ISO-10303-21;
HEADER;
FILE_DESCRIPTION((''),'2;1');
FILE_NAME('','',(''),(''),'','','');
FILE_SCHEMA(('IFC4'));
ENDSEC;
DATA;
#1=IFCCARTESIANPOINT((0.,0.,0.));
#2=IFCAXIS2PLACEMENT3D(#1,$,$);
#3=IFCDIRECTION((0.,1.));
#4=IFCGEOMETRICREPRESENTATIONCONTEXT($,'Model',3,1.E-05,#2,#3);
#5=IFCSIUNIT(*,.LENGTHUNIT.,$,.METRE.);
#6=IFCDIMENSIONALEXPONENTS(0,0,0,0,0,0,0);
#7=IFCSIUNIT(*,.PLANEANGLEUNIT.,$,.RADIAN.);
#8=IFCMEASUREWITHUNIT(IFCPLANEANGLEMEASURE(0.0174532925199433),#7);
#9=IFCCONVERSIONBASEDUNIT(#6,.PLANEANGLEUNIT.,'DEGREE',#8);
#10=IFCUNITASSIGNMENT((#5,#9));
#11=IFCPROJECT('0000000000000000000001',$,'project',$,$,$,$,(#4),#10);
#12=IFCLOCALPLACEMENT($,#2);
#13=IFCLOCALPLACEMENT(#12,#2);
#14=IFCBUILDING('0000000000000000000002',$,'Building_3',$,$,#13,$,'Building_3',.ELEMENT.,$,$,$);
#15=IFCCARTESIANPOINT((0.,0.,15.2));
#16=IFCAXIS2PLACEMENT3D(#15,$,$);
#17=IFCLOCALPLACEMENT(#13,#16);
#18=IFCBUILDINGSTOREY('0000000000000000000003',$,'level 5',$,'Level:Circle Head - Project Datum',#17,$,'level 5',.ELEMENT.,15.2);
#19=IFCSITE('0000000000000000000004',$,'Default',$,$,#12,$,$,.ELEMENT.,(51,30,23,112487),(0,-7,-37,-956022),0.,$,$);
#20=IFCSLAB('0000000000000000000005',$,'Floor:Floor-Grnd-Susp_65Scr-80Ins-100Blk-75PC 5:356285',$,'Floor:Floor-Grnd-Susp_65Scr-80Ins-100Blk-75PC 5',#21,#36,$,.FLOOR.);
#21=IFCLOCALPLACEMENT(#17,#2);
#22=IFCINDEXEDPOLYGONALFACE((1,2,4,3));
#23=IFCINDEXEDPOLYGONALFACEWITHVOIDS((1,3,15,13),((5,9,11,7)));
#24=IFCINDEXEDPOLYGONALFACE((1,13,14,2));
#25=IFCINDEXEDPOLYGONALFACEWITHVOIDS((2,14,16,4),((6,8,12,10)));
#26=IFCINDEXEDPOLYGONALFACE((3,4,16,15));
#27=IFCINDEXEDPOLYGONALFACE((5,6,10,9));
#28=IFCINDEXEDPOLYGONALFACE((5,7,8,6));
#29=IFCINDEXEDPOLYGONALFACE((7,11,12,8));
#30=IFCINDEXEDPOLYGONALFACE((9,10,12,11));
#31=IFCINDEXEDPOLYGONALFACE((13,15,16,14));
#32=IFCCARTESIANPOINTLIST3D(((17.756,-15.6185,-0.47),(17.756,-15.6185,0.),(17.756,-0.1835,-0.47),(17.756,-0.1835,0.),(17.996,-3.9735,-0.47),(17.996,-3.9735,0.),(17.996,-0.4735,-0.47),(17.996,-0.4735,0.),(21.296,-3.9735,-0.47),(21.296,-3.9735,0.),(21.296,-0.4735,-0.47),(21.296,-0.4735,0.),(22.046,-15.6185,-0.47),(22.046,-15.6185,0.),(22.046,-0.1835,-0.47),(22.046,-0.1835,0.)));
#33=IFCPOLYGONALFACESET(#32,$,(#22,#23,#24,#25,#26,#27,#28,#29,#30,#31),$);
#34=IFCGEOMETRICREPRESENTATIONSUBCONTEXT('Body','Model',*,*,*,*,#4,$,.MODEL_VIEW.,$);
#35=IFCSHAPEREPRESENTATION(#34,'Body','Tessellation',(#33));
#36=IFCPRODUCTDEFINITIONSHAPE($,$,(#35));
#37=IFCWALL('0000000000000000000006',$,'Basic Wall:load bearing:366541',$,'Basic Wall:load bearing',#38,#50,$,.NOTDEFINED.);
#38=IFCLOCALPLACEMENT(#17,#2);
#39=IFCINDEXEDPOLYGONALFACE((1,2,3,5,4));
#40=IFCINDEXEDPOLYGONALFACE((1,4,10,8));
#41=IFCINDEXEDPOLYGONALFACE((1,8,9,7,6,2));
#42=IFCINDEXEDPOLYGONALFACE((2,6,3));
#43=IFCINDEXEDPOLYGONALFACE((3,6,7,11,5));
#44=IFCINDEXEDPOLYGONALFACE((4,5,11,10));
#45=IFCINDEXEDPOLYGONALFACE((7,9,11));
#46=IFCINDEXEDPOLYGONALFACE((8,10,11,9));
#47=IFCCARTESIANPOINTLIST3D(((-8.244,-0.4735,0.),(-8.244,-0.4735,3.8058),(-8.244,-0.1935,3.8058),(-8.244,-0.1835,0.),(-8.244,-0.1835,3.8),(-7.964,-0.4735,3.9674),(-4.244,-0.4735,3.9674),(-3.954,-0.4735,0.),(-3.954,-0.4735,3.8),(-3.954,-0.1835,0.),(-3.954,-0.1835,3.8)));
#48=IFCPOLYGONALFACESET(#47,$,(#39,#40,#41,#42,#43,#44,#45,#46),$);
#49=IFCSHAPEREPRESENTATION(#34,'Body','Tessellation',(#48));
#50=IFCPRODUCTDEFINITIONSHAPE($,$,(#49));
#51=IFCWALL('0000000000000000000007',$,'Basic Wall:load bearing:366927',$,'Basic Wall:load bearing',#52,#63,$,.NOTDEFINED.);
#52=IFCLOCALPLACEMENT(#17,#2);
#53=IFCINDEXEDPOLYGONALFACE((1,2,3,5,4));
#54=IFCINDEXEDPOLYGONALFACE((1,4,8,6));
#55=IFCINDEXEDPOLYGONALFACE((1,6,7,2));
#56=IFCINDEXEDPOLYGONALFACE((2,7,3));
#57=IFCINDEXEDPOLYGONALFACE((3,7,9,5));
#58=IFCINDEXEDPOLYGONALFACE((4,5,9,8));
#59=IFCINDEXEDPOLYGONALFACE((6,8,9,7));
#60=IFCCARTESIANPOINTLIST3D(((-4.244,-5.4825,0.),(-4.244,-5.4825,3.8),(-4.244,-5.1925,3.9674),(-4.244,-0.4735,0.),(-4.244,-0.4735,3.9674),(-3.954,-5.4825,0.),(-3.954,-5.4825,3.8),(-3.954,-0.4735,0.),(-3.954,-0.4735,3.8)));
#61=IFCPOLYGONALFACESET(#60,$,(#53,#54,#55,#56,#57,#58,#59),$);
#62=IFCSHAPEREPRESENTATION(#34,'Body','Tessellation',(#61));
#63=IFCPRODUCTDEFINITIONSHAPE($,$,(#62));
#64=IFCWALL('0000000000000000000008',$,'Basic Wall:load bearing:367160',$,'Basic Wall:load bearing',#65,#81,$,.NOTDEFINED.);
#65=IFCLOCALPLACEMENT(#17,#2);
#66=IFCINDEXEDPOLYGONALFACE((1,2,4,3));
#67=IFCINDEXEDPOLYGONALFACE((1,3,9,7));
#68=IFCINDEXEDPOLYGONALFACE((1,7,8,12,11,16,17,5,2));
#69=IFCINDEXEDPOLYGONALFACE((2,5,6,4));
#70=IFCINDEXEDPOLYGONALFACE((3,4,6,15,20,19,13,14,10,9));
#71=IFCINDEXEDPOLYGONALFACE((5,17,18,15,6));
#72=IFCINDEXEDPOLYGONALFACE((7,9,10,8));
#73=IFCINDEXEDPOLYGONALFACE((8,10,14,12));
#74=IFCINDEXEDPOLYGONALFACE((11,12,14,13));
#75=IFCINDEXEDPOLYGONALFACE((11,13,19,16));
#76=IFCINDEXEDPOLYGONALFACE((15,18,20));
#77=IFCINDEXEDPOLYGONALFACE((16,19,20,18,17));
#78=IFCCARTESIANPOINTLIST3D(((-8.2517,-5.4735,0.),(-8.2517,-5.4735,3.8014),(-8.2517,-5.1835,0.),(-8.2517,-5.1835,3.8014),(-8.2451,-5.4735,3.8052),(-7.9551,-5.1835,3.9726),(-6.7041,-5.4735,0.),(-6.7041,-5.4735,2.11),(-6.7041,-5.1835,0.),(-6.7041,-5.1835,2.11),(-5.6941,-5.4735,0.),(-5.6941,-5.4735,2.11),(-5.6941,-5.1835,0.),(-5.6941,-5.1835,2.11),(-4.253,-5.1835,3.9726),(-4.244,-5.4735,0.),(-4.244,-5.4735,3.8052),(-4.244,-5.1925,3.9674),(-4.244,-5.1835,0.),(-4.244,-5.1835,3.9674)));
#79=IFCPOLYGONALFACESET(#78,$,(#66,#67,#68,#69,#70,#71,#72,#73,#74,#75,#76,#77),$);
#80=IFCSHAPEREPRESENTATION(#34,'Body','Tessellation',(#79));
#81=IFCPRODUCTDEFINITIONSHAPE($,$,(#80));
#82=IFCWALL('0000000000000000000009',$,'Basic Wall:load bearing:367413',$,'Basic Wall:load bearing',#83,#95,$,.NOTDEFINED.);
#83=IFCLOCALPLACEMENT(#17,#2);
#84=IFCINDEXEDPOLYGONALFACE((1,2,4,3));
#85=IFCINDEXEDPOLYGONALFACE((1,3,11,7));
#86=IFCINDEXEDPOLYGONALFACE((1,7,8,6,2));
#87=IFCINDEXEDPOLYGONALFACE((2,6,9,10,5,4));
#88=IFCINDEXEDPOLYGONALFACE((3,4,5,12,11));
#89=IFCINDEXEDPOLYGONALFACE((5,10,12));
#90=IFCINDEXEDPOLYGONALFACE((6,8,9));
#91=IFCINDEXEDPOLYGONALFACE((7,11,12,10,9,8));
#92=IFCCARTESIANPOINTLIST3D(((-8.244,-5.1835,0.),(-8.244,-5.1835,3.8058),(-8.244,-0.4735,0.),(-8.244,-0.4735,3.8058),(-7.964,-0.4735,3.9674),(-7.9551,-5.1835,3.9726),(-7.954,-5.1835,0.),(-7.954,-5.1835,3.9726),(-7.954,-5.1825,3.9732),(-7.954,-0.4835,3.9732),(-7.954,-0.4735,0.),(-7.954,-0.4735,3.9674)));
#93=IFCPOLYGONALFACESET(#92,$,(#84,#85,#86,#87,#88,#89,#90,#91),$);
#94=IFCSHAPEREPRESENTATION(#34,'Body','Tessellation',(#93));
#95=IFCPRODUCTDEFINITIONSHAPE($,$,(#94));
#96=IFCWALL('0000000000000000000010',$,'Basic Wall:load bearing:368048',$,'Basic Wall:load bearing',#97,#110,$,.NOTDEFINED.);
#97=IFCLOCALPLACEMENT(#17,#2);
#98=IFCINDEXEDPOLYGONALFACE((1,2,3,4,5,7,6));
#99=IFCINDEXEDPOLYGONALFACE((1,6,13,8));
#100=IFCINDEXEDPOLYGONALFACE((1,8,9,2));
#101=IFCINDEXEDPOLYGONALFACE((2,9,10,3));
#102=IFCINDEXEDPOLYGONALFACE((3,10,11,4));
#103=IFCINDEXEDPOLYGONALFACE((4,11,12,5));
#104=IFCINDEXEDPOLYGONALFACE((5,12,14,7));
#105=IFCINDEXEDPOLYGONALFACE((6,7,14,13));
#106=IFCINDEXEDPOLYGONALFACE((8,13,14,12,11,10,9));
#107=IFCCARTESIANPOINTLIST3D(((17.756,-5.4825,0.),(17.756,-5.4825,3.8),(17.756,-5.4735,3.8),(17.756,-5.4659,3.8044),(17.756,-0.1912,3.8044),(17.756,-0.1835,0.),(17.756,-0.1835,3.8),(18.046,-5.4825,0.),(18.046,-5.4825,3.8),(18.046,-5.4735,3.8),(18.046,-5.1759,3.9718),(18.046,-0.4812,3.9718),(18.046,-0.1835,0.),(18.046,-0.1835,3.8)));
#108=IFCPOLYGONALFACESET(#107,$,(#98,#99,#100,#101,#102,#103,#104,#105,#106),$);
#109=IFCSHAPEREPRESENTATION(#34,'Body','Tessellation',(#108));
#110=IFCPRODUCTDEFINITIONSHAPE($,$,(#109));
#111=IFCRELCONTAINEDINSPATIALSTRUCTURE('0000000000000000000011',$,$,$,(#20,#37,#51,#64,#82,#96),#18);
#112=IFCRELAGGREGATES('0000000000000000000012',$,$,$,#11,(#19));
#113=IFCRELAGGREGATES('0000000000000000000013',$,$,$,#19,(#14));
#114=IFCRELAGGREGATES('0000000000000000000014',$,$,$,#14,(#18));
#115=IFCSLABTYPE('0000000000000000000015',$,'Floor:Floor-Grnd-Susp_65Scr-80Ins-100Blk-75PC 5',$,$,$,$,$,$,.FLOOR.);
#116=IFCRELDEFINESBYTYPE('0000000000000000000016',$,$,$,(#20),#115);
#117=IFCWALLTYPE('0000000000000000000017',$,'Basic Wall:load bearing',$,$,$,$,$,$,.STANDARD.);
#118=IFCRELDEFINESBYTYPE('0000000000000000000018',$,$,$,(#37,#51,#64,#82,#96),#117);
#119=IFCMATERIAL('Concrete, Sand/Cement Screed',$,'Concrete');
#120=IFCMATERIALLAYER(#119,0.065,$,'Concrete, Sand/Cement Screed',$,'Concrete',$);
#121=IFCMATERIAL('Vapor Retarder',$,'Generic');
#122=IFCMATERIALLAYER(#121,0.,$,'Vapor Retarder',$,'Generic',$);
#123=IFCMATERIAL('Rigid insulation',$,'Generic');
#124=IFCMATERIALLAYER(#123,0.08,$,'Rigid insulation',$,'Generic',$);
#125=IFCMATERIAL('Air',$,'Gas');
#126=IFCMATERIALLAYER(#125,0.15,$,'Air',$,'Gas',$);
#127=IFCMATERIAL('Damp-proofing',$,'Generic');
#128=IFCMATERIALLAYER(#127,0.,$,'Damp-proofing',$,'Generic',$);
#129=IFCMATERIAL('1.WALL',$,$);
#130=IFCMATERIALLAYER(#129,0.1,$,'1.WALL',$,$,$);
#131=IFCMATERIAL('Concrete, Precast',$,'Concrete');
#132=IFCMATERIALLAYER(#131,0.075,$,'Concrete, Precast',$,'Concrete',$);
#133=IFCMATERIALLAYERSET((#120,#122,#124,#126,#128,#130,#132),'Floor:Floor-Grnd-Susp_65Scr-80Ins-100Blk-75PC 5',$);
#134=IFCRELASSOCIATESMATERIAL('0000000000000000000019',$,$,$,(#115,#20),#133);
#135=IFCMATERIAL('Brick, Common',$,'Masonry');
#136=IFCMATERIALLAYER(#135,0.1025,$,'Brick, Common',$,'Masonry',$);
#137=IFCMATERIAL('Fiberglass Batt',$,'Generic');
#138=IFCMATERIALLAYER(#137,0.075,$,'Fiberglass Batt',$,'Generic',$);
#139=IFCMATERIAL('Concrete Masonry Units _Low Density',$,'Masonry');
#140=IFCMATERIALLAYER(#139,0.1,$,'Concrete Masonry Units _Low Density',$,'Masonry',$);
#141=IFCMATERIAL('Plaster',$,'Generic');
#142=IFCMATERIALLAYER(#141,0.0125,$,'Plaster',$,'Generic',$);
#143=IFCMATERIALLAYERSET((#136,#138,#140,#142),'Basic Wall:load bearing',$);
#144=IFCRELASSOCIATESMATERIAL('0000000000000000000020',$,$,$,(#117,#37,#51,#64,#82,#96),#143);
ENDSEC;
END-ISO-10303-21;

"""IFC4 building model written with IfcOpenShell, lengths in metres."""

from ifc_helpers import new_model, entity, si_unit, converted_unit, direction, frame, frame_2d, origin, place, context, subcontext, project, spatial, polyline, rectangle, extrude, boolean, clip, bounded_halfspace, material, layer, layer_set, layer_usage, type_object, element, save


model = new_model("IFC4")

# Units and contexts
model_context = context("Model", 3, precision=1e-05, world=origin(), true_north=direction((0.0, 1.0)))
body_context = subcontext(model_context, "Body", "Model", "MODEL_VIEW")
ifc_project = project(units=[si_unit("LENGTHUNIT", "METRE"), converted_unit("PLANEANGLEUNIT", "DEGREE", entity("IfcPlaneAngleMeasure", 0.0174532925199433), si_unit("PLANEANGLEUNIT", "RADIAN"), dimensions=[0, 0, 0, 0, 0, 0, 0])], contexts=[model_context])

# Site, building, storey
site_placement = place(None, origin())
site = spatial("IfcSite", under=ifc_project, at=site_placement, Name="Default", CompositionType="ELEMENT", RefLatitude=(51, 30, 23, 112487), RefLongitude=(0, -7, -37, -956022), RefElevation=0.0)
building_placement = place(site_placement, origin())
building = spatial("IfcBuilding", under=site, at=building_placement, Name="Building_3", LongName="Building_3", CompositionType="ELEMENT")
storey_placement = place(building_placement, frame((0.0, 0.0, 15.2)))
storey = spatial("IfcBuildingStorey", under=building, at=storey_placement, Name="level 5", ObjectType="Level:Circle Head - Project Datum", LongName="level 5", CompositionType="ELEMENT", Elevation=15.2)

# Slab, opening
ifc_material_1 = material(Name="Concrete, Sand/Cement Screed", Category="Concrete")
ifc_material_2 = material(Name="Vapor Retarder", Category="Generic")
ifc_material_3 = material(Name="Rigid insulation", Category="Generic")
ifc_material_4 = material(Name="Air", Category="Gas")
ifc_material_5 = material(Name="Damp-proofing", Category="Generic")
ifc_material_6 = material(Name="1.WALL")
ifc_material_7 = material(Name="Concrete, Precast", Category="Concrete")
ifc_layer_1 = layer(ifc_material_1, 0.065, Name="Concrete, Sand/Cement Screed", Category="Concrete")
ifc_layer_2 = layer(ifc_material_2, 0.0, Name="Vapor Retarder", Category="Generic")
ifc_layer_3 = layer(ifc_material_3, 0.08, Name="Rigid insulation", Category="Generic")
ifc_layer_4 = layer(ifc_material_4, 0.15, Name="Air", Category="Gas")
ifc_layer_5 = layer(ifc_material_5, 0.0, Name="Damp-proofing", Category="Generic")
ifc_layer_6 = layer(ifc_material_6, 0.1, Name="1.WALL")
ifc_layer_7 = layer(ifc_material_7, 0.075, Name="Concrete, Precast", Category="Concrete")
ifc_layer_set_1 = layer_set([ifc_layer_1, ifc_layer_2, ifc_layer_3, ifc_layer_4, ifc_layer_5, ifc_layer_6, ifc_layer_7], Name="Floor:Floor-Grnd-Susp_65Scr-80Ins-100Blk-75PC 5")
ifc_layer_usage_1 = layer_usage(ifc_layer_set_1, "AXIS3", "POSITIVE", 0.0)
slab_type_1 = type_object("IfcSlabType", Name="Floor:Floor-Grnd-Susp_65Scr-80Ins-100Blk-75PC 5", PredefinedType="FLOOR", material=ifc_layer_set_1)
slab_1_placement = place(storey_placement, origin())
slab_1 = element("IfcSlab", 1, at=slab_1_placement, inside=storey, type_object=slab_type_1, material=ifc_layer_usage_1, Name="Floor:Floor-Grnd-Susp_65Scr-80Ins-100Blk-75PC 5:356285", ObjectType="Floor:Floor-Grnd-Susp_65Scr-80Ins-100Blk-75PC 5", PredefinedType="FLOOR", context=body_context, shape_type="SweptSolid", body=[
    boolean("DIFFERENCE", extrude(rectangle(XDim=15.435, YDim=4.29, at=frame_2d((0.0, 0.0), x_axis=(1.0, 0.0))), frame((19.901, -7.901, 0.0), z_axis=(0.0, 0.0, -1.0), x_axis=(0.0, 1.0, 0.0)), (0.0, 0.0, 1.0), 0.47), extrude(rectangle(XDim=3.5, YDim=3.3, at=frame_2d((0.0, 0.0), x_axis=(1.0, 0.0))), frame((19.646, -2.2235, -0.47), z_axis=(0.0, 0.0, 1.0), x_axis=(0.0, 1.0, 0.0)), (0.0, 0.0, 1.0), 0.47)),
])
opening_1_placement = place(slab_1_placement, origin())
element("IfcOpeningElement", 2, at=opening_1_placement, cuts=slab_1, PredefinedType="OPENING", context=body_context, shape_type="SweptSolid", body=[
    extrude(rectangle(XDim=3.5, YDim=3.3, at=frame_2d((0.0, 0.0), x_axis=(1.0, 0.0))), frame((19.646, -2.2235, 0.0), z_axis=(0.0, 0.0, 1.0), x_axis=(0.0, -1.0, 0.0)), (0.0, 0.0, -1.0), 0.47),
])

# Walls
ifc_material_8 = material(Name="Brick, Common", Category="Masonry")
ifc_layer_8 = layer(ifc_material_8, 0.1025, Name="Brick, Common", Category="Masonry")
ifc_material_9 = material(Name="Fiberglass Batt", Category="Generic")
ifc_layer_9 = layer(ifc_material_9, 0.075, Name="Fiberglass Batt", Category="Generic")
ifc_material_10 = material(Name="Concrete Masonry Units _Low Density", Category="Masonry")
ifc_layer_10 = layer(ifc_material_10, 0.1, Name="Concrete Masonry Units _Low Density", Category="Masonry")
ifc_material_11 = material(Name="Plaster", Category="Generic")
ifc_layer_11 = layer(ifc_material_11, 0.0125, Name="Plaster", Category="Generic")
ifc_layer_set_2 = layer_set([ifc_layer_8, ifc_layer_9, ifc_layer_10, ifc_layer_11], Name="Basic Wall:load bearing")
ifc_layer_usage_2 = layer_usage(ifc_layer_set_2, "AXIS2", "NEGATIVE", 0.145)
wall_type = type_object("IfcWallType", Name="Basic Wall:load bearing", PredefinedType="STANDARD", material=ifc_layer_set_2)
wall_1_placement = place(storey_placement, frame((-8.244, -0.3285, 0.0)))
element("IfcWall", 3, at=wall_1_placement, inside=storey, type_object=wall_type, material=ifc_layer_usage_2, Name="Basic Wall:load bearing:366541", ObjectType="Basic Wall:load bearing", PredefinedType="NOTDEFINED", context=body_context, shape_type="Clipping", body=[
    clip(clip(clip(extrude(rectangle(XDim=4.29, YDim=0.29, at=frame_2d((2.145, 0.0), x_axis=(-1.0, 0.0))), origin(), (0.0, 0.0, 1.0), 3.9674), bounded_halfspace(frame((0.28, -0.145, 3.9674), z_axis=(0.0, 0.5, 0.866025), x_axis=(-1.0, 0.0, 0.0)), False, frame((0.28, -0.145, 3.9674)), polyline([(0.0, 0.0), (0.01, 0.0), (3.72, 0.0), (4.01, 0.29), (-0.28, 0.29), (-0.28, 0.28), (0.0, 0.0)]))), bounded_halfspace(frame((4.0, -0.145, 3.9674), z_axis=(0.5, 0.0, 0.866025), x_axis=(0.0, 1.0, 0.0)), False, frame((4.0, -0.145, 3.9674)), polyline([(0.0, 0.0), (0.29, 0.0), (0.29, 0.29), (0.0, 0.0)]))), bounded_halfspace(frame((0.0, -0.145, 3.8058), z_axis=(-0.5, 0.0, 0.866025), x_axis=(0.0, -1.0, 0.0)), False, frame((0.0, -0.145, 3.8058)), polyline([(0.0, 0.0), (0.28, 0.0), (0.0, 0.28), (0.0, 0.0)]))),
])
ifc_layer_usage_3 = layer_usage(ifc_layer_set_2, "AXIS2", "NEGATIVE", 0.145)
wall_2_placement = place(storey_placement, frame((-4.099, -0.4735, 0.0), z_axis=(0.0, 0.0, 1.0), x_axis=(0.0, -1.0, 0.0)))
element("IfcWall", 4, at=wall_2_placement, inside=storey, type_object=wall_type, material=ifc_layer_usage_3, Name="Basic Wall:load bearing:366927", ObjectType="Basic Wall:load bearing", PredefinedType="NOTDEFINED", context=body_context, shape_type="Clipping", body=[
    clip(clip(extrude(rectangle(XDim=5.0089, YDim=0.29, at=frame_2d((2.5045, 0.0), x_axis=(-1.0, 0.0))), origin(), (0.0, 0.0, 1.0), 3.9674), bounded_halfspace(frame((0.0, -0.145, 3.9674), z_axis=(0.0, 0.5, 0.866025), x_axis=(-1.0, 0.0, 0.0)), False, frame((0.0, -0.145, 3.9674)), polyline([(0.0, 0.0), (4.71, 0.0), (4.719, 0.0), (5.0089, 0.29), (0.0, 0.29), (0.0, 0.0)]))), bounded_halfspace(frame((4.719, -0.145, 3.9674), z_axis=(0.5, 0.0, 0.866025), x_axis=(0.0, 1.0, 0.0)), False, frame((4.719, -0.145, 3.9674)), polyline([(0.0, 0.0), (0.281, 0.0), (0.29, 0.0), (0.29, 0.29), (0.0, 0.0)]))),
])

# Wall, opening
ifc_layer_usage_4 = layer_usage(ifc_layer_set_2, "AXIS2", "NEGATIVE", 0.145)
wall_3_placement = place(storey_placement, frame((-4.244, -5.3285, 0.0), z_axis=(0.0, 0.0, 1.0), x_axis=(-1.0, 0.0, 0.0)))
wall_3 = element("IfcWall", 5, at=wall_3_placement, inside=storey, type_object=wall_type, material=ifc_layer_usage_4, Name="Basic Wall:load bearing:367160", ObjectType="Basic Wall:load bearing", PredefinedType="NOTDEFINED", context=body_context, shape_type="Clipping", body=[
    clip(clip(clip(extrude(rectangle(XDim=0.29, YDim=4.0077, at=frame_2d((2.0038, 0.0), x_axis=(0.0, 1.0))), origin(), (0.0, 0.0, 1.0), 3.9726), bounded_halfspace(frame((0.0, -0.145, 3.9674), z_axis=(-0.5, 0.0, 0.866025), x_axis=(0.0, -1.0, 0.0)), False, frame((0.0, -0.145, 3.9674)), polyline([(0.0, 0.0), (0.009, 0.0), (0.0, 0.009), (0.0, 0.0)]))), bounded_halfspace(frame((0.009, -0.145, 3.9726), z_axis=(0.0, 0.5, 0.866025), x_axis=(-1.0, 0.0, 0.0)), False, frame((0.009, -0.145, 3.9726)), polyline([(0.0, 0.0), (3.7021, 0.0), (3.9921, 0.29), (-0.009, 0.29), (-0.009, 0.009), (0.0, 0.0)]))), bounded_halfspace(frame((4.0077, -0.145, 3.8014), z_axis=(0.5, 0.0, 0.866025), x_axis=(0.0, 1.0, 0.0)), False, frame((4.0077, -0.145, 3.8014)), polyline([(0.0, 0.0), (0.0, 0.29), (-0.0066, 0.29), (-0.2966, 0.0), (-0.0076, 0.0), (0.0, 0.0)]))),
])
opening_2_placement = place(wall_3_placement, frame((1.4501, -0.145, 0.0)))
element("IfcOpeningElement", 6, at=opening_2_placement, cuts=wall_3, PredefinedType="OPENING", context=body_context, shape_type="SweptSolid", body=[
    extrude(rectangle(XDim=2.11, YDim=1.01, at=frame_2d((1.055, 0.505), x_axis=(1.0, 0.0))), frame((0.0, 0.0, 0.0), z_axis=(0.0, 1.0, 0.0), x_axis=(0.0, 0.0, 1.0)), (0.0, 0.0, 1.0), 0.29),
])

# Walls
ifc_layer_usage_5 = layer_usage(ifc_layer_set_2, "AXIS2", "NEGATIVE", 0.145)
wall_4_placement = place(storey_placement, frame((-8.099, -5.1835, 0.0), z_axis=(0.0, 0.0, 1.0), x_axis=(0.0, 1.0, 0.0)))
element("IfcWall", 7, at=wall_4_placement, inside=storey, type_object=wall_type, material=ifc_layer_usage_5, Name="Basic Wall:load bearing:367413", ObjectType="Basic Wall:load bearing", PredefinedType="NOTDEFINED", context=body_context, shape_type="Clipping", body=[
    clip(clip(clip(extrude(rectangle(XDim=4.71, YDim=0.29, at=frame_2d((2.355, 0.0), x_axis=(-1.0, 0.0))), origin(), (0.0, 0.0, 1.0), 3.9732), bounded_halfspace(frame((4.7, -0.145, 3.9732), z_axis=(0.5, 0.0, 0.866025), x_axis=(0.0, 1.0, 0.0)), False, frame((4.7, -0.145, 3.9732)), polyline([(0.0, 0.0), (0.01, 0.0), (0.01, 0.01), (0.0, 0.0)]))), bounded_halfspace(frame((0.0, -0.145, 3.9726), z_axis=(-0.5, 0.0, 0.866025), x_axis=(0.0, -1.0, 0.0)), False, frame((0.0, -0.145, 3.9726)), polyline([(0.0, 0.0), (0.001, 0.0), (0.0, 0.001), (0.0, 0.0)]))), bounded_halfspace(frame((0.0, -0.145, 3.9732), z_axis=(0.0, 0.5, 0.866025), x_axis=(-1.0, 0.0, 0.0)), False, frame((0.0, -0.145, 3.9732)), polyline([(0.0, 0.0), (4.7, 0.0), (4.71, 0.01), (4.71, 0.29), (0.0, 0.29), (0.0, 0.0)]))),
])
ifc_layer_usage_6 = layer_usage(ifc_layer_set_2, "AXIS2", "NEGATIVE", 0.145)
wall_5_placement = place(storey_placement, frame((17.901, -0.1835, 0.0), z_axis=(0.0, 0.0, 1.0), x_axis=(0.0, -1.0, 0.0)))
element("IfcWall", 8, at=wall_5_placement, inside=storey, type_object=wall_type, material=ifc_layer_usage_6, Name="Basic Wall:load bearing:368048", ObjectType="Basic Wall:load bearing", PredefinedType="NOTDEFINED", context=body_context, shape_type="Clipping", body=[
    clip(clip(clip(clip(extrude(rectangle(XDim=5.2989, YDim=0.29, at=frame_2d((2.6495, 0.0), x_axis=(-1.0, 0.0))), origin(), (0.0, 0.0, 1.0), 3.9718), bounded_halfspace(frame((0.0, -0.145, 3.8), z_axis=(-0.5, 0.0, 0.866025), x_axis=(0.0, -1.0, 0.0)), False, frame((0.0, -0.145, 3.8)), polyline([(0.0, 0.0), (0.0076, 0.0), (0.2977, 0.29), (0.0, 0.29), (0.0, 0.0)]))), bounded_halfspace(frame((5.2824, -0.145, 3.8044), z_axis=(0.5, 0.0, 0.866025), x_axis=(0.0, 1.0, 0.0)), False, frame((5.2824, -0.145, 3.8044)), polyline([(0.0, 0.0), (0.0076, 0.0), (0.0076, 0.29), (-0.29, 0.29), (0.0, 0.0)]))), bounded_halfspace(frame((0.0077, -0.145, 3.8044), z_axis=(0.0, -0.5, 0.866025), x_axis=(1.0, 0.0, 0.0)), False, frame((0.0077, -0.145, 3.8044)), polyline([(0.0, 0.0), (5.2747, 0.0), (4.9847, 0.29), (0.29, 0.29), (0.0, 0.0)]))), bounded_halfspace(frame((5.29, -0.145, 3.8), z_axis=(0.0, 0.0, 1.0), x_axis=(0.0, 1.0, 0.0)), False, frame((5.29, -0.145, 3.8)), polyline([(0.0, 0.0), (0.0089, 0.0), (0.0089, 0.29), (0.0, 0.29), (0.0, 0.0)]))),
])

save(model, "model.ifc")
